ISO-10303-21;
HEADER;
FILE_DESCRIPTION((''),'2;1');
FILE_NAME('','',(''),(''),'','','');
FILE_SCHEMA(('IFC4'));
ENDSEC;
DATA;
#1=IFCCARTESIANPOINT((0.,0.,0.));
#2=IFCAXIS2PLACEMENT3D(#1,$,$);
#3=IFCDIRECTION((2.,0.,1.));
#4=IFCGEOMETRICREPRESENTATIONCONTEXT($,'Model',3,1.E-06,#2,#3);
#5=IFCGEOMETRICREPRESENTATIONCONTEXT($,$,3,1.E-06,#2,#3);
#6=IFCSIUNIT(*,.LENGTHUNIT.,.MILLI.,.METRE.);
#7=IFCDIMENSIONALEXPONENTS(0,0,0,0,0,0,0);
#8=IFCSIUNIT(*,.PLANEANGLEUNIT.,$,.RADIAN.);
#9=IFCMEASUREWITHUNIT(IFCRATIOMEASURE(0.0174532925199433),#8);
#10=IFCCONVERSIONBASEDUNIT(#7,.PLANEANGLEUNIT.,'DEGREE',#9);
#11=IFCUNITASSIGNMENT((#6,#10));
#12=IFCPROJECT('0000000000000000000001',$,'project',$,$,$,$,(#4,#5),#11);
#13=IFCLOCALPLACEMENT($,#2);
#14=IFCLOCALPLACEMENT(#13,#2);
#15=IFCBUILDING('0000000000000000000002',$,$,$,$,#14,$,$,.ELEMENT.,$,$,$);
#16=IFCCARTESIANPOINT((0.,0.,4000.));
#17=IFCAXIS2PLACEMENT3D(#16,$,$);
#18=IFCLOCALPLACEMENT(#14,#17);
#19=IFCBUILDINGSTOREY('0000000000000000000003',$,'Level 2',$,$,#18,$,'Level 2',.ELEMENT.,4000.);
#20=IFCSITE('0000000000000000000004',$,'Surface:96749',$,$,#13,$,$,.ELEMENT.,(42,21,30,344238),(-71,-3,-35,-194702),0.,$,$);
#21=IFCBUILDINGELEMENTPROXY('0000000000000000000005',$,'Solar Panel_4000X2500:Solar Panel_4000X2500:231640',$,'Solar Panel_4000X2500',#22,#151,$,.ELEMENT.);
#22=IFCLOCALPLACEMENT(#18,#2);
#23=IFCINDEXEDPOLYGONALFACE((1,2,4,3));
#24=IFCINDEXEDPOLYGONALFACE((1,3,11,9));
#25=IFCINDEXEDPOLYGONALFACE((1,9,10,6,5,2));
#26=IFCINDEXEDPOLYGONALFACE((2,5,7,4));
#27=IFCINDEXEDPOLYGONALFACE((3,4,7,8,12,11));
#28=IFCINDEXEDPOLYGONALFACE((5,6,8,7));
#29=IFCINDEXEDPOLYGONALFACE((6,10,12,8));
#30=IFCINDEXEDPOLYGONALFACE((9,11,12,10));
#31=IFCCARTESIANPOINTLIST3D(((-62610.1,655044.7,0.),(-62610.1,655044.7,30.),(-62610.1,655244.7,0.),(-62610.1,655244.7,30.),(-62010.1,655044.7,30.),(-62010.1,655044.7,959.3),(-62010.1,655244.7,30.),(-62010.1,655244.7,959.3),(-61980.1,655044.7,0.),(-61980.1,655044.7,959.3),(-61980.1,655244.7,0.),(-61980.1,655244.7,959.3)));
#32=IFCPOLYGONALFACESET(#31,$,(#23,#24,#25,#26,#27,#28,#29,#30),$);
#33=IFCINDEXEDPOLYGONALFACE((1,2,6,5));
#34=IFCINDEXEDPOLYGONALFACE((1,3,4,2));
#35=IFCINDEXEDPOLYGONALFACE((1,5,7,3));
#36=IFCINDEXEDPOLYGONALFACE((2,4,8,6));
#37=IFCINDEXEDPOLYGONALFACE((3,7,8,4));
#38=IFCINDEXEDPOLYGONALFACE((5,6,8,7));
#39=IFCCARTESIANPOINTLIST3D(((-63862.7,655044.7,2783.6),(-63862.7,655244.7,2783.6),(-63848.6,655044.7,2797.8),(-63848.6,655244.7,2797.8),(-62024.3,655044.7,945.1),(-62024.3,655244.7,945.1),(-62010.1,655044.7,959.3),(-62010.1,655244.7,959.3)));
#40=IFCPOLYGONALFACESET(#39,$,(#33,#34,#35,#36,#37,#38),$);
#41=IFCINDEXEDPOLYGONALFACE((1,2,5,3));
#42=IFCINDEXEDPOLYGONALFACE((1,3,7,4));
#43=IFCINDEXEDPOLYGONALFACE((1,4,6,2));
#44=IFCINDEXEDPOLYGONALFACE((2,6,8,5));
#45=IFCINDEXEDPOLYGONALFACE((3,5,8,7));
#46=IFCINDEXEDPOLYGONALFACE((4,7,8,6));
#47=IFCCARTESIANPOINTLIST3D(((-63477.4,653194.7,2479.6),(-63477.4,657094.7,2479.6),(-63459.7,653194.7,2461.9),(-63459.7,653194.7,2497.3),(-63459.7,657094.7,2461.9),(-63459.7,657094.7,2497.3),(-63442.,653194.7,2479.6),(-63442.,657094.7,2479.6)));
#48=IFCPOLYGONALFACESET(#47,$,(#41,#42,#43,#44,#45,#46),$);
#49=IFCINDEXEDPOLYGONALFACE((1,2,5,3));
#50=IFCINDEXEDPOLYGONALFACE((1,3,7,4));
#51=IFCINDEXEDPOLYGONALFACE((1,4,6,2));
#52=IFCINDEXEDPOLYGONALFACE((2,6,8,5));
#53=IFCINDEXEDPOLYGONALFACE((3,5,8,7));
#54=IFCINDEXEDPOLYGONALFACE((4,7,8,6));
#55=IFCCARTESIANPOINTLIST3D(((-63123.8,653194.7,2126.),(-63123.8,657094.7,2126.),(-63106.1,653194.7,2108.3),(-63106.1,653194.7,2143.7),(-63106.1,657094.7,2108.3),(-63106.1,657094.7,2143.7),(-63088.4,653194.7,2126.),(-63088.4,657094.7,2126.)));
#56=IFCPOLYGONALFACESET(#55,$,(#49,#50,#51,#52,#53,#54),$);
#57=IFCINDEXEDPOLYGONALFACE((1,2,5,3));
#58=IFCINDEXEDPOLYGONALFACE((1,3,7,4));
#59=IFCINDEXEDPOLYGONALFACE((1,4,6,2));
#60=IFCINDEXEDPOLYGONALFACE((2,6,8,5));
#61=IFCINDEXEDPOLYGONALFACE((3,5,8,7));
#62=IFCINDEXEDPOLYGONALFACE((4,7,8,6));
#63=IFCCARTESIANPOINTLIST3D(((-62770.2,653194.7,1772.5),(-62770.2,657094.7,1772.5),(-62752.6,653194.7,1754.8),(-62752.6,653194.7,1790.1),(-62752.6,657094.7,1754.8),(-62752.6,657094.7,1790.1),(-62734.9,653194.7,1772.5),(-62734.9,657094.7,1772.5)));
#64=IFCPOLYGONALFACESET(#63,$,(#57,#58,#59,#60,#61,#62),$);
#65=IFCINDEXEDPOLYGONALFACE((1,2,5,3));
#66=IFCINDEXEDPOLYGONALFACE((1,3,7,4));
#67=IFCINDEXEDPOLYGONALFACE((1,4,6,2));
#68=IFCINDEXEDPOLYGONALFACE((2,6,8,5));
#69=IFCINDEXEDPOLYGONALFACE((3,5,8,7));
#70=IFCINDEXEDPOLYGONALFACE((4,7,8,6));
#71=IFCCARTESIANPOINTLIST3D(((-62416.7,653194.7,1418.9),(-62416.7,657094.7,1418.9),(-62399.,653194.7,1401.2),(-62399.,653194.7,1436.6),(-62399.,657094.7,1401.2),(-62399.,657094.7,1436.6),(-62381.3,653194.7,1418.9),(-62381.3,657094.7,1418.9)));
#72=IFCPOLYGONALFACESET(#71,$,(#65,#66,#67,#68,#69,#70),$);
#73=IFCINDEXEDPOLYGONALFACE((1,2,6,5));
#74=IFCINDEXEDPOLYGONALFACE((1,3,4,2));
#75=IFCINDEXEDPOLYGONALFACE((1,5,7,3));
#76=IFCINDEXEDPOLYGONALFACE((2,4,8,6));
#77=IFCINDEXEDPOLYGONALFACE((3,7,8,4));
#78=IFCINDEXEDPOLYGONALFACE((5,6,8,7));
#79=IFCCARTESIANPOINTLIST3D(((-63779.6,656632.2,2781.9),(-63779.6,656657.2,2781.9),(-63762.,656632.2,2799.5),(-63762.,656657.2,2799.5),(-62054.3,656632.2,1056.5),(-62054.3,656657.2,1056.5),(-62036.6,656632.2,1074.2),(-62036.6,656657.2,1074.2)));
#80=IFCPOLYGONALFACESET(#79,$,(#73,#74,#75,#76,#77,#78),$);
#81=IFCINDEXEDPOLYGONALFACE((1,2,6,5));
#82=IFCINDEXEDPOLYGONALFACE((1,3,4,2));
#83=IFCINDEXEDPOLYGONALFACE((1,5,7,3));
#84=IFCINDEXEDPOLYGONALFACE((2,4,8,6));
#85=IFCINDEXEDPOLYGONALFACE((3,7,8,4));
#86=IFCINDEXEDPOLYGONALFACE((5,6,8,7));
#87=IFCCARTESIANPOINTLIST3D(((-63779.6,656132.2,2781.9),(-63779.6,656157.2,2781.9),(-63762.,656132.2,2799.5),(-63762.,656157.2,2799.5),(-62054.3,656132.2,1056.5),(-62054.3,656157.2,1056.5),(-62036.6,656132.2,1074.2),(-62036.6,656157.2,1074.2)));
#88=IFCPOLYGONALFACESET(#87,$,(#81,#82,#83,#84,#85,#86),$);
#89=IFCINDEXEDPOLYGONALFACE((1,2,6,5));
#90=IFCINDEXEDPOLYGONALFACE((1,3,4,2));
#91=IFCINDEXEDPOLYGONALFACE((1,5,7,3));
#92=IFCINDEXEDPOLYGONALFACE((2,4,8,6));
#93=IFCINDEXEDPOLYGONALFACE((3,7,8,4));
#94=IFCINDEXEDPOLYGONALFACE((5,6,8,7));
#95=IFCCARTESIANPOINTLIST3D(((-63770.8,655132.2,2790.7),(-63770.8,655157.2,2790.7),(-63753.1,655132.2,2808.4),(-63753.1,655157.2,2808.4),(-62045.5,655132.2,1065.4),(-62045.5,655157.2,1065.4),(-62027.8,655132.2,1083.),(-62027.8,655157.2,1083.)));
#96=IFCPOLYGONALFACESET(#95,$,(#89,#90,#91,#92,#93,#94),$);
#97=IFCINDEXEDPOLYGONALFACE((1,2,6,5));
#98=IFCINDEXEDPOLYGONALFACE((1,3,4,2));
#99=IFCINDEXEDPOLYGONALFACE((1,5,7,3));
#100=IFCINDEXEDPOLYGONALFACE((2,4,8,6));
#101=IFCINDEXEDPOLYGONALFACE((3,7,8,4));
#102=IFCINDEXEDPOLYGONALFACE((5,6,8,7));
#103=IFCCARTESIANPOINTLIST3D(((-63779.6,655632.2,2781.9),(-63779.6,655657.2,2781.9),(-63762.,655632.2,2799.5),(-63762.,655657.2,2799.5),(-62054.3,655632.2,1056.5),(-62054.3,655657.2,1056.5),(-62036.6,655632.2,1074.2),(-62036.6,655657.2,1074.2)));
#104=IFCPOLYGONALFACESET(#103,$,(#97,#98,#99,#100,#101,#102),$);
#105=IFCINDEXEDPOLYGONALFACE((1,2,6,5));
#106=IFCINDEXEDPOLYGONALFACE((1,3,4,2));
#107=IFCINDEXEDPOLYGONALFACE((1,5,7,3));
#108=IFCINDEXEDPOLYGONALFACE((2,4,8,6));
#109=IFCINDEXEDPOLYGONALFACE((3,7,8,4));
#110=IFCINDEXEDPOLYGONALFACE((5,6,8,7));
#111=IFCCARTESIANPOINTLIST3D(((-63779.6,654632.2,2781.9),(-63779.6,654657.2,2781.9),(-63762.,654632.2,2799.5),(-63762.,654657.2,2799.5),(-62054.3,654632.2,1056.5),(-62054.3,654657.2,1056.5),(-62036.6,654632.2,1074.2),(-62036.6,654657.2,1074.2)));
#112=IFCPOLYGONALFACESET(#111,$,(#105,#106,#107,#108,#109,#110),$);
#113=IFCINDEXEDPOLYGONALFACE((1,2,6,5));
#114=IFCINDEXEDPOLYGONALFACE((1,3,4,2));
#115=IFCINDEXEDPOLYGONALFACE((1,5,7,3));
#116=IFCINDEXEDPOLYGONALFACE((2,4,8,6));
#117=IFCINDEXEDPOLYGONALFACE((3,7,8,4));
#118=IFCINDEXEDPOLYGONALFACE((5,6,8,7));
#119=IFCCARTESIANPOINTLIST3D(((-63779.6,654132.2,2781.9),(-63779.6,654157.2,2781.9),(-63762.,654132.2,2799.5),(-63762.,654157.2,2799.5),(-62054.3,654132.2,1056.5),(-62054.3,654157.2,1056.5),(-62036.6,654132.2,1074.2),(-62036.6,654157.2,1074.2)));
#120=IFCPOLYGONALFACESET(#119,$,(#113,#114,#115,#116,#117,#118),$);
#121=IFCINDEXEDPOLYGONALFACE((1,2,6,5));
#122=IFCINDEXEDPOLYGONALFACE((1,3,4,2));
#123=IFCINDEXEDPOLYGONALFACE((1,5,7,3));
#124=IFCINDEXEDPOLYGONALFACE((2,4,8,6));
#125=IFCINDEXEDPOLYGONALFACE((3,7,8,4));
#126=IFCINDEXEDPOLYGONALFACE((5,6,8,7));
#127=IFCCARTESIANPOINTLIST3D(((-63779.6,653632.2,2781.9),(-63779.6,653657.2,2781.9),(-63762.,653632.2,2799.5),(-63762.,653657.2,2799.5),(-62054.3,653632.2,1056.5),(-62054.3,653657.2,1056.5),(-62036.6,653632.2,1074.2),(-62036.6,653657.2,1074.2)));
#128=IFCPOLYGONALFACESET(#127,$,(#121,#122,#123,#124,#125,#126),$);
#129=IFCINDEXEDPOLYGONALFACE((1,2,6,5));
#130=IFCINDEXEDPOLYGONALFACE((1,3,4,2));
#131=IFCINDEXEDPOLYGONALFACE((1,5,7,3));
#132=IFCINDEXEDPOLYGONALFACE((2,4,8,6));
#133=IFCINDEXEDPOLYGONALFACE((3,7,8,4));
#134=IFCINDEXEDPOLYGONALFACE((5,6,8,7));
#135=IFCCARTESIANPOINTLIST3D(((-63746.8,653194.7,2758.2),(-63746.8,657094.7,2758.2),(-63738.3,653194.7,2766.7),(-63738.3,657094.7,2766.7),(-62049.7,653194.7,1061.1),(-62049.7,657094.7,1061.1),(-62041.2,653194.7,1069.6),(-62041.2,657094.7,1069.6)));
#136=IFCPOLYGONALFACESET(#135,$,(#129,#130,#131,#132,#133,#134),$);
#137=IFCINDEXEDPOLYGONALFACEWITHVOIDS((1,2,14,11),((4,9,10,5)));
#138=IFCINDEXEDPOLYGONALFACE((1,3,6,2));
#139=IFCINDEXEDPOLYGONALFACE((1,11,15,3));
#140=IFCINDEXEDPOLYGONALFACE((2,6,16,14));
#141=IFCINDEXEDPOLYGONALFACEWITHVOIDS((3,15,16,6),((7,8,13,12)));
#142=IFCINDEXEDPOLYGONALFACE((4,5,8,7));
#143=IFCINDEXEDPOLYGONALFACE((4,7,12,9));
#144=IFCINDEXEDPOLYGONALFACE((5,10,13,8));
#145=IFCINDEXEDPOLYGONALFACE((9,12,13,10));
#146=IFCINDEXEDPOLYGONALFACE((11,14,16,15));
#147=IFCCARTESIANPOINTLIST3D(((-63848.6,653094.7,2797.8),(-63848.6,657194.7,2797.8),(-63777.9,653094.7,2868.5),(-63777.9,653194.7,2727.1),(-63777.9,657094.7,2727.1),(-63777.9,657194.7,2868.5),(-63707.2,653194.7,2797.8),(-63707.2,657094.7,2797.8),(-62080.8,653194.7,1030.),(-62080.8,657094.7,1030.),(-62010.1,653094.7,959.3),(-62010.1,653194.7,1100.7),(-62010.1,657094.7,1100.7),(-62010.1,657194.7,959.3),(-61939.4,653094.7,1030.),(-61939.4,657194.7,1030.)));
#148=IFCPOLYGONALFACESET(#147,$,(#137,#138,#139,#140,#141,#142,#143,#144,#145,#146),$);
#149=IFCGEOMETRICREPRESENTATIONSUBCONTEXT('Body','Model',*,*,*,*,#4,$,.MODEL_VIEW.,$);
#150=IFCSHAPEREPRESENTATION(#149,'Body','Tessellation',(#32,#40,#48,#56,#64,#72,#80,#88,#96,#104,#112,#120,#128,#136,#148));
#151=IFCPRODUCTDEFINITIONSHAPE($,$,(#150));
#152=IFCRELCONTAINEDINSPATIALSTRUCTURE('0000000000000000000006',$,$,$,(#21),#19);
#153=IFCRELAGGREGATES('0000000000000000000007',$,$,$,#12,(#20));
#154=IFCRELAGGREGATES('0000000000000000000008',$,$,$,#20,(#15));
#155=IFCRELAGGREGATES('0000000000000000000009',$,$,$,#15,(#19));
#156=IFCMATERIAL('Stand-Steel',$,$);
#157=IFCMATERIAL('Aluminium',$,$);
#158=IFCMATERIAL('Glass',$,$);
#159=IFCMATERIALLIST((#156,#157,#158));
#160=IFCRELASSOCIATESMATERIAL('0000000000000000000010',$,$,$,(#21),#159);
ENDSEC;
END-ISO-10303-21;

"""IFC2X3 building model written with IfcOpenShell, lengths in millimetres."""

from ifc_helpers import new_model, entity, si_unit, converted_unit, direction, frame, frame_2d, origin, origin_2d_with_axis, place, context, subcontext, project, spatial, polyline, rectangle, outline, extrude, source, transform, mapped, material, material_list, element, save


model = new_model("IFC2X3")

# Units and contexts
model_context = context("Model", 3, precision=1e-06, world=origin(), true_north=direction((2.0, 0.0, 1.0)))
context_of_model = context(None, 3, precision=1e-06, world=origin(), true_north=direction((2.0, 0.0, 1.0)))
body_context = subcontext(model_context, "Body", "Model", "MODEL_VIEW")
ifc_project = project(units=[si_unit("LENGTHUNIT", "METRE", prefix="MILLI"), converted_unit("PLANEANGLEUNIT", "DEGREE", entity("IfcRatioMeasure", 0.0174532925199433), si_unit("PLANEANGLEUNIT", "RADIAN"), dimensions=[0, 0, 0, 0, 0, 0, 0])], contexts=[model_context, context_of_model])

# Site, building, storey
site_placement = place(None, origin())
site = spatial("IfcSite", under=ifc_project, at=site_placement, Name="Surface:96749", CompositionType="ELEMENT", RefLatitude=(42, 21, 30, 344238), RefLongitude=(-71, -3, -35, -194702), RefElevation=0.0)
building_placement = place(site_placement, origin())
building = spatial("IfcBuilding", under=site, at=building_placement, CompositionType="ELEMENT")
storey_placement = place(building_placement, frame((0.0, 0.0, 4000.0)))
storey = spatial("IfcBuildingStorey", under=building, at=storey_placement, Name="Level 2", LongName="Level 2", CompositionType="ELEMENT", Elevation=4000.0)

# Building element proxy
ifc_material_1 = material(Name="Stand-Steel")
ifc_material_2 = material(Name="Aluminium")
ifc_material_3 = material(Name="Glass")
shared_shape = source(origin(), body_context, "Body", "SweptSolid", [
    extrude(outline(polyline([(-629.5, -220.0), (329.8, -220.0), (329.8, 410.0), (299.8, 410.0), (299.8, -190.0), (-629.5, -190.0), (-629.5, -220.0)])), frame((-190.0, -100.0, 299.8), z_axis=(0.0, 1.0, 0.0), x_axis=(0.0, 0.0, -1.0)), (0.0, 0.0, 1.0), 200.0),
    extrude(rectangle(XDim=20.0, YDim=200.0, at=frame_2d((0.0, 0.0), x_axis=(0.0, 1.0))), frame((-7.1, 0.0, 922.2), z_axis=(-0.707107, 0.0, 0.707107), x_axis=(0.0, 1.0, 0.0)), (0.0, 0.0, 1.0), 2600.0),
    extrude(rectangle(XDim=25.0, YDim=25.0, at=frame_2d((0.0, 0.0), x_axis=(1.0, 0.0))), frame((-1449.6, -1950.0, 2449.6), z_axis=(0.0, 1.0, 0.0), x_axis=(-0.707107, 0.0, -0.707107)), (0.0, 0.0, 1.0), 3900.0),
    extrude(rectangle(XDim=25.0, YDim=25.0, at=origin_2d_with_axis()), frame((-1096.0, -1950.0, 2096.0), z_axis=(0.0, 1.0, 0.0), x_axis=(-0.707107, 0.0, -0.707107)), (0.0, 0.0, 1.0), 3900.0),
    extrude(rectangle(XDim=25.0, YDim=25.0, at=origin_2d_with_axis()), frame((-742.5, -1950.0, 1742.5), z_axis=(0.0, 1.0, 0.0), x_axis=(-0.707107, 0.0, -0.707107)), (0.0, 0.0, 1.0), 3900.0),
    extrude(rectangle(XDim=25.0, YDim=25.0, at=frame_2d((0.0, 0.0), x_axis=(1.0, 0.0))), frame((-388.9, -1950.0, 1388.9), z_axis=(0.0, 1.0, 0.0), x_axis=(-0.707107, 0.0, -0.707107)), (0.0, 0.0, 1.0), 3900.0),
    extrude(rectangle(XDim=25.0, YDim=25.0, at=frame_2d((0.0, 0.0), x_axis=(0.0, 1.0))), frame((-35.4, 1500.0, 1035.4), z_axis=(-0.707107, 0.0, 0.707107), x_axis=(0.0, 1.0, 0.0)), (0.0, 0.0, 1.0), 2440.0),
    extrude(rectangle(XDim=25.0, YDim=25.0, at=frame_2d((0.0, 0.0), x_axis=(0.0, 1.0))), frame((-35.4, 1000.0, 1035.4), z_axis=(-0.707107, 0.0, 0.707107), x_axis=(0.0, 1.0, 0.0)), (0.0, 0.0, 1.0), 2440.0),
    extrude(rectangle(XDim=25.0, YDim=25.0, at=frame_2d((0.0, 0.0), x_axis=(0.0, 1.0))), frame((-26.5, 0.0, 1044.2), z_axis=(-0.707107, 0.0, 0.707107), x_axis=(0.0, -1.0, 0.0)), (0.0, 0.0, 1.0), 2440.0),
    extrude(rectangle(XDim=25.0, YDim=25.0, at=frame_2d((0.0, 0.0), x_axis=(0.0, 1.0))), frame((-35.4, 500.0, 1035.4), z_axis=(-0.707107, 0.0, 0.707107), x_axis=(0.0, 1.0, 0.0)), (0.0, 0.0, 1.0), 2440.0),
    extrude(rectangle(XDim=25.0, YDim=25.0, at=frame_2d((0.0, 0.0), x_axis=(0.0, 1.0))), frame((-35.4, -500.0, 1035.4), z_axis=(-0.707107, 0.0, 0.707107), x_axis=(0.0, 1.0, 0.0)), (0.0, 0.0, 1.0), 2440.0),
    extrude(rectangle(XDim=25.0, YDim=25.0, at=frame_2d((0.0, 0.0), x_axis=(0.0, 1.0))), frame((-35.4, -1000.0, 1035.4), z_axis=(-0.707107, 0.0, 0.707107), x_axis=(0.0, 1.0, 0.0)), (0.0, 0.0, 1.0), 2440.0),
    extrude(rectangle(XDim=25.0, YDim=25.0, at=frame_2d((0.0, 0.0), x_axis=(0.0, 1.0))), frame((-35.4, -1500.0, 1035.4), z_axis=(-0.707107, 0.0, 0.707107), x_axis=(0.0, 1.0, 0.0)), (0.0, 0.0, 1.0), 2440.0),
    extrude(rectangle(XDim=2400.0, YDim=12.0, at=frame_2d((0.0, 0.0), x_axis=(1.0, 0.0))), frame((-883.9, -1950.0, 1883.9), z_axis=(0.0, 1.0, 0.0), x_axis=(0.707107, 0.0, -0.707107)), (0.0, 0.0, 1.0), 3900.0),
    extrude(outline(polyline([(-2050.0, -1300.0), (2050.0, -1300.0), (2050.0, 1300.0), (-2050.0, 1300.0), (-2050.0, -1300.0)]), holes=[polyline([(1950.0, -1200.0), (-1950.0, -1200.0), (-1950.0, 1200.0), (1950.0, 1200.0), (1950.0, -1200.0)])]), frame((-919.2, 0.0, 1848.5), z_axis=(0.707107, 0.0, 0.707107), x_axis=(0.0, 1.0, 0.0)), (0.0, 0.0, 1.0), 100.0),
])
ifc_material_list_1 = material_list([ifc_material_1, ifc_material_2, ifc_material_3])
proxy_1_placement = place(storey_placement, frame((-62010.1, 655144.7, 30.0)))
element("IfcBuildingElementProxy", 1, at=proxy_1_placement, inside=storey, material=ifc_material_list_1, Name="Solar Panel_4000X2500:Solar Panel_4000X2500:231640", ObjectType="Solar Panel_4000X2500", CompositionType="ELEMENT", context=body_context, shape_type="MappedRepresentation", body=[
    mapped(shared_shape, transform((0.0, 0.0, 0.0), scale=1.0)),
])

save(model, "model.ifc")
